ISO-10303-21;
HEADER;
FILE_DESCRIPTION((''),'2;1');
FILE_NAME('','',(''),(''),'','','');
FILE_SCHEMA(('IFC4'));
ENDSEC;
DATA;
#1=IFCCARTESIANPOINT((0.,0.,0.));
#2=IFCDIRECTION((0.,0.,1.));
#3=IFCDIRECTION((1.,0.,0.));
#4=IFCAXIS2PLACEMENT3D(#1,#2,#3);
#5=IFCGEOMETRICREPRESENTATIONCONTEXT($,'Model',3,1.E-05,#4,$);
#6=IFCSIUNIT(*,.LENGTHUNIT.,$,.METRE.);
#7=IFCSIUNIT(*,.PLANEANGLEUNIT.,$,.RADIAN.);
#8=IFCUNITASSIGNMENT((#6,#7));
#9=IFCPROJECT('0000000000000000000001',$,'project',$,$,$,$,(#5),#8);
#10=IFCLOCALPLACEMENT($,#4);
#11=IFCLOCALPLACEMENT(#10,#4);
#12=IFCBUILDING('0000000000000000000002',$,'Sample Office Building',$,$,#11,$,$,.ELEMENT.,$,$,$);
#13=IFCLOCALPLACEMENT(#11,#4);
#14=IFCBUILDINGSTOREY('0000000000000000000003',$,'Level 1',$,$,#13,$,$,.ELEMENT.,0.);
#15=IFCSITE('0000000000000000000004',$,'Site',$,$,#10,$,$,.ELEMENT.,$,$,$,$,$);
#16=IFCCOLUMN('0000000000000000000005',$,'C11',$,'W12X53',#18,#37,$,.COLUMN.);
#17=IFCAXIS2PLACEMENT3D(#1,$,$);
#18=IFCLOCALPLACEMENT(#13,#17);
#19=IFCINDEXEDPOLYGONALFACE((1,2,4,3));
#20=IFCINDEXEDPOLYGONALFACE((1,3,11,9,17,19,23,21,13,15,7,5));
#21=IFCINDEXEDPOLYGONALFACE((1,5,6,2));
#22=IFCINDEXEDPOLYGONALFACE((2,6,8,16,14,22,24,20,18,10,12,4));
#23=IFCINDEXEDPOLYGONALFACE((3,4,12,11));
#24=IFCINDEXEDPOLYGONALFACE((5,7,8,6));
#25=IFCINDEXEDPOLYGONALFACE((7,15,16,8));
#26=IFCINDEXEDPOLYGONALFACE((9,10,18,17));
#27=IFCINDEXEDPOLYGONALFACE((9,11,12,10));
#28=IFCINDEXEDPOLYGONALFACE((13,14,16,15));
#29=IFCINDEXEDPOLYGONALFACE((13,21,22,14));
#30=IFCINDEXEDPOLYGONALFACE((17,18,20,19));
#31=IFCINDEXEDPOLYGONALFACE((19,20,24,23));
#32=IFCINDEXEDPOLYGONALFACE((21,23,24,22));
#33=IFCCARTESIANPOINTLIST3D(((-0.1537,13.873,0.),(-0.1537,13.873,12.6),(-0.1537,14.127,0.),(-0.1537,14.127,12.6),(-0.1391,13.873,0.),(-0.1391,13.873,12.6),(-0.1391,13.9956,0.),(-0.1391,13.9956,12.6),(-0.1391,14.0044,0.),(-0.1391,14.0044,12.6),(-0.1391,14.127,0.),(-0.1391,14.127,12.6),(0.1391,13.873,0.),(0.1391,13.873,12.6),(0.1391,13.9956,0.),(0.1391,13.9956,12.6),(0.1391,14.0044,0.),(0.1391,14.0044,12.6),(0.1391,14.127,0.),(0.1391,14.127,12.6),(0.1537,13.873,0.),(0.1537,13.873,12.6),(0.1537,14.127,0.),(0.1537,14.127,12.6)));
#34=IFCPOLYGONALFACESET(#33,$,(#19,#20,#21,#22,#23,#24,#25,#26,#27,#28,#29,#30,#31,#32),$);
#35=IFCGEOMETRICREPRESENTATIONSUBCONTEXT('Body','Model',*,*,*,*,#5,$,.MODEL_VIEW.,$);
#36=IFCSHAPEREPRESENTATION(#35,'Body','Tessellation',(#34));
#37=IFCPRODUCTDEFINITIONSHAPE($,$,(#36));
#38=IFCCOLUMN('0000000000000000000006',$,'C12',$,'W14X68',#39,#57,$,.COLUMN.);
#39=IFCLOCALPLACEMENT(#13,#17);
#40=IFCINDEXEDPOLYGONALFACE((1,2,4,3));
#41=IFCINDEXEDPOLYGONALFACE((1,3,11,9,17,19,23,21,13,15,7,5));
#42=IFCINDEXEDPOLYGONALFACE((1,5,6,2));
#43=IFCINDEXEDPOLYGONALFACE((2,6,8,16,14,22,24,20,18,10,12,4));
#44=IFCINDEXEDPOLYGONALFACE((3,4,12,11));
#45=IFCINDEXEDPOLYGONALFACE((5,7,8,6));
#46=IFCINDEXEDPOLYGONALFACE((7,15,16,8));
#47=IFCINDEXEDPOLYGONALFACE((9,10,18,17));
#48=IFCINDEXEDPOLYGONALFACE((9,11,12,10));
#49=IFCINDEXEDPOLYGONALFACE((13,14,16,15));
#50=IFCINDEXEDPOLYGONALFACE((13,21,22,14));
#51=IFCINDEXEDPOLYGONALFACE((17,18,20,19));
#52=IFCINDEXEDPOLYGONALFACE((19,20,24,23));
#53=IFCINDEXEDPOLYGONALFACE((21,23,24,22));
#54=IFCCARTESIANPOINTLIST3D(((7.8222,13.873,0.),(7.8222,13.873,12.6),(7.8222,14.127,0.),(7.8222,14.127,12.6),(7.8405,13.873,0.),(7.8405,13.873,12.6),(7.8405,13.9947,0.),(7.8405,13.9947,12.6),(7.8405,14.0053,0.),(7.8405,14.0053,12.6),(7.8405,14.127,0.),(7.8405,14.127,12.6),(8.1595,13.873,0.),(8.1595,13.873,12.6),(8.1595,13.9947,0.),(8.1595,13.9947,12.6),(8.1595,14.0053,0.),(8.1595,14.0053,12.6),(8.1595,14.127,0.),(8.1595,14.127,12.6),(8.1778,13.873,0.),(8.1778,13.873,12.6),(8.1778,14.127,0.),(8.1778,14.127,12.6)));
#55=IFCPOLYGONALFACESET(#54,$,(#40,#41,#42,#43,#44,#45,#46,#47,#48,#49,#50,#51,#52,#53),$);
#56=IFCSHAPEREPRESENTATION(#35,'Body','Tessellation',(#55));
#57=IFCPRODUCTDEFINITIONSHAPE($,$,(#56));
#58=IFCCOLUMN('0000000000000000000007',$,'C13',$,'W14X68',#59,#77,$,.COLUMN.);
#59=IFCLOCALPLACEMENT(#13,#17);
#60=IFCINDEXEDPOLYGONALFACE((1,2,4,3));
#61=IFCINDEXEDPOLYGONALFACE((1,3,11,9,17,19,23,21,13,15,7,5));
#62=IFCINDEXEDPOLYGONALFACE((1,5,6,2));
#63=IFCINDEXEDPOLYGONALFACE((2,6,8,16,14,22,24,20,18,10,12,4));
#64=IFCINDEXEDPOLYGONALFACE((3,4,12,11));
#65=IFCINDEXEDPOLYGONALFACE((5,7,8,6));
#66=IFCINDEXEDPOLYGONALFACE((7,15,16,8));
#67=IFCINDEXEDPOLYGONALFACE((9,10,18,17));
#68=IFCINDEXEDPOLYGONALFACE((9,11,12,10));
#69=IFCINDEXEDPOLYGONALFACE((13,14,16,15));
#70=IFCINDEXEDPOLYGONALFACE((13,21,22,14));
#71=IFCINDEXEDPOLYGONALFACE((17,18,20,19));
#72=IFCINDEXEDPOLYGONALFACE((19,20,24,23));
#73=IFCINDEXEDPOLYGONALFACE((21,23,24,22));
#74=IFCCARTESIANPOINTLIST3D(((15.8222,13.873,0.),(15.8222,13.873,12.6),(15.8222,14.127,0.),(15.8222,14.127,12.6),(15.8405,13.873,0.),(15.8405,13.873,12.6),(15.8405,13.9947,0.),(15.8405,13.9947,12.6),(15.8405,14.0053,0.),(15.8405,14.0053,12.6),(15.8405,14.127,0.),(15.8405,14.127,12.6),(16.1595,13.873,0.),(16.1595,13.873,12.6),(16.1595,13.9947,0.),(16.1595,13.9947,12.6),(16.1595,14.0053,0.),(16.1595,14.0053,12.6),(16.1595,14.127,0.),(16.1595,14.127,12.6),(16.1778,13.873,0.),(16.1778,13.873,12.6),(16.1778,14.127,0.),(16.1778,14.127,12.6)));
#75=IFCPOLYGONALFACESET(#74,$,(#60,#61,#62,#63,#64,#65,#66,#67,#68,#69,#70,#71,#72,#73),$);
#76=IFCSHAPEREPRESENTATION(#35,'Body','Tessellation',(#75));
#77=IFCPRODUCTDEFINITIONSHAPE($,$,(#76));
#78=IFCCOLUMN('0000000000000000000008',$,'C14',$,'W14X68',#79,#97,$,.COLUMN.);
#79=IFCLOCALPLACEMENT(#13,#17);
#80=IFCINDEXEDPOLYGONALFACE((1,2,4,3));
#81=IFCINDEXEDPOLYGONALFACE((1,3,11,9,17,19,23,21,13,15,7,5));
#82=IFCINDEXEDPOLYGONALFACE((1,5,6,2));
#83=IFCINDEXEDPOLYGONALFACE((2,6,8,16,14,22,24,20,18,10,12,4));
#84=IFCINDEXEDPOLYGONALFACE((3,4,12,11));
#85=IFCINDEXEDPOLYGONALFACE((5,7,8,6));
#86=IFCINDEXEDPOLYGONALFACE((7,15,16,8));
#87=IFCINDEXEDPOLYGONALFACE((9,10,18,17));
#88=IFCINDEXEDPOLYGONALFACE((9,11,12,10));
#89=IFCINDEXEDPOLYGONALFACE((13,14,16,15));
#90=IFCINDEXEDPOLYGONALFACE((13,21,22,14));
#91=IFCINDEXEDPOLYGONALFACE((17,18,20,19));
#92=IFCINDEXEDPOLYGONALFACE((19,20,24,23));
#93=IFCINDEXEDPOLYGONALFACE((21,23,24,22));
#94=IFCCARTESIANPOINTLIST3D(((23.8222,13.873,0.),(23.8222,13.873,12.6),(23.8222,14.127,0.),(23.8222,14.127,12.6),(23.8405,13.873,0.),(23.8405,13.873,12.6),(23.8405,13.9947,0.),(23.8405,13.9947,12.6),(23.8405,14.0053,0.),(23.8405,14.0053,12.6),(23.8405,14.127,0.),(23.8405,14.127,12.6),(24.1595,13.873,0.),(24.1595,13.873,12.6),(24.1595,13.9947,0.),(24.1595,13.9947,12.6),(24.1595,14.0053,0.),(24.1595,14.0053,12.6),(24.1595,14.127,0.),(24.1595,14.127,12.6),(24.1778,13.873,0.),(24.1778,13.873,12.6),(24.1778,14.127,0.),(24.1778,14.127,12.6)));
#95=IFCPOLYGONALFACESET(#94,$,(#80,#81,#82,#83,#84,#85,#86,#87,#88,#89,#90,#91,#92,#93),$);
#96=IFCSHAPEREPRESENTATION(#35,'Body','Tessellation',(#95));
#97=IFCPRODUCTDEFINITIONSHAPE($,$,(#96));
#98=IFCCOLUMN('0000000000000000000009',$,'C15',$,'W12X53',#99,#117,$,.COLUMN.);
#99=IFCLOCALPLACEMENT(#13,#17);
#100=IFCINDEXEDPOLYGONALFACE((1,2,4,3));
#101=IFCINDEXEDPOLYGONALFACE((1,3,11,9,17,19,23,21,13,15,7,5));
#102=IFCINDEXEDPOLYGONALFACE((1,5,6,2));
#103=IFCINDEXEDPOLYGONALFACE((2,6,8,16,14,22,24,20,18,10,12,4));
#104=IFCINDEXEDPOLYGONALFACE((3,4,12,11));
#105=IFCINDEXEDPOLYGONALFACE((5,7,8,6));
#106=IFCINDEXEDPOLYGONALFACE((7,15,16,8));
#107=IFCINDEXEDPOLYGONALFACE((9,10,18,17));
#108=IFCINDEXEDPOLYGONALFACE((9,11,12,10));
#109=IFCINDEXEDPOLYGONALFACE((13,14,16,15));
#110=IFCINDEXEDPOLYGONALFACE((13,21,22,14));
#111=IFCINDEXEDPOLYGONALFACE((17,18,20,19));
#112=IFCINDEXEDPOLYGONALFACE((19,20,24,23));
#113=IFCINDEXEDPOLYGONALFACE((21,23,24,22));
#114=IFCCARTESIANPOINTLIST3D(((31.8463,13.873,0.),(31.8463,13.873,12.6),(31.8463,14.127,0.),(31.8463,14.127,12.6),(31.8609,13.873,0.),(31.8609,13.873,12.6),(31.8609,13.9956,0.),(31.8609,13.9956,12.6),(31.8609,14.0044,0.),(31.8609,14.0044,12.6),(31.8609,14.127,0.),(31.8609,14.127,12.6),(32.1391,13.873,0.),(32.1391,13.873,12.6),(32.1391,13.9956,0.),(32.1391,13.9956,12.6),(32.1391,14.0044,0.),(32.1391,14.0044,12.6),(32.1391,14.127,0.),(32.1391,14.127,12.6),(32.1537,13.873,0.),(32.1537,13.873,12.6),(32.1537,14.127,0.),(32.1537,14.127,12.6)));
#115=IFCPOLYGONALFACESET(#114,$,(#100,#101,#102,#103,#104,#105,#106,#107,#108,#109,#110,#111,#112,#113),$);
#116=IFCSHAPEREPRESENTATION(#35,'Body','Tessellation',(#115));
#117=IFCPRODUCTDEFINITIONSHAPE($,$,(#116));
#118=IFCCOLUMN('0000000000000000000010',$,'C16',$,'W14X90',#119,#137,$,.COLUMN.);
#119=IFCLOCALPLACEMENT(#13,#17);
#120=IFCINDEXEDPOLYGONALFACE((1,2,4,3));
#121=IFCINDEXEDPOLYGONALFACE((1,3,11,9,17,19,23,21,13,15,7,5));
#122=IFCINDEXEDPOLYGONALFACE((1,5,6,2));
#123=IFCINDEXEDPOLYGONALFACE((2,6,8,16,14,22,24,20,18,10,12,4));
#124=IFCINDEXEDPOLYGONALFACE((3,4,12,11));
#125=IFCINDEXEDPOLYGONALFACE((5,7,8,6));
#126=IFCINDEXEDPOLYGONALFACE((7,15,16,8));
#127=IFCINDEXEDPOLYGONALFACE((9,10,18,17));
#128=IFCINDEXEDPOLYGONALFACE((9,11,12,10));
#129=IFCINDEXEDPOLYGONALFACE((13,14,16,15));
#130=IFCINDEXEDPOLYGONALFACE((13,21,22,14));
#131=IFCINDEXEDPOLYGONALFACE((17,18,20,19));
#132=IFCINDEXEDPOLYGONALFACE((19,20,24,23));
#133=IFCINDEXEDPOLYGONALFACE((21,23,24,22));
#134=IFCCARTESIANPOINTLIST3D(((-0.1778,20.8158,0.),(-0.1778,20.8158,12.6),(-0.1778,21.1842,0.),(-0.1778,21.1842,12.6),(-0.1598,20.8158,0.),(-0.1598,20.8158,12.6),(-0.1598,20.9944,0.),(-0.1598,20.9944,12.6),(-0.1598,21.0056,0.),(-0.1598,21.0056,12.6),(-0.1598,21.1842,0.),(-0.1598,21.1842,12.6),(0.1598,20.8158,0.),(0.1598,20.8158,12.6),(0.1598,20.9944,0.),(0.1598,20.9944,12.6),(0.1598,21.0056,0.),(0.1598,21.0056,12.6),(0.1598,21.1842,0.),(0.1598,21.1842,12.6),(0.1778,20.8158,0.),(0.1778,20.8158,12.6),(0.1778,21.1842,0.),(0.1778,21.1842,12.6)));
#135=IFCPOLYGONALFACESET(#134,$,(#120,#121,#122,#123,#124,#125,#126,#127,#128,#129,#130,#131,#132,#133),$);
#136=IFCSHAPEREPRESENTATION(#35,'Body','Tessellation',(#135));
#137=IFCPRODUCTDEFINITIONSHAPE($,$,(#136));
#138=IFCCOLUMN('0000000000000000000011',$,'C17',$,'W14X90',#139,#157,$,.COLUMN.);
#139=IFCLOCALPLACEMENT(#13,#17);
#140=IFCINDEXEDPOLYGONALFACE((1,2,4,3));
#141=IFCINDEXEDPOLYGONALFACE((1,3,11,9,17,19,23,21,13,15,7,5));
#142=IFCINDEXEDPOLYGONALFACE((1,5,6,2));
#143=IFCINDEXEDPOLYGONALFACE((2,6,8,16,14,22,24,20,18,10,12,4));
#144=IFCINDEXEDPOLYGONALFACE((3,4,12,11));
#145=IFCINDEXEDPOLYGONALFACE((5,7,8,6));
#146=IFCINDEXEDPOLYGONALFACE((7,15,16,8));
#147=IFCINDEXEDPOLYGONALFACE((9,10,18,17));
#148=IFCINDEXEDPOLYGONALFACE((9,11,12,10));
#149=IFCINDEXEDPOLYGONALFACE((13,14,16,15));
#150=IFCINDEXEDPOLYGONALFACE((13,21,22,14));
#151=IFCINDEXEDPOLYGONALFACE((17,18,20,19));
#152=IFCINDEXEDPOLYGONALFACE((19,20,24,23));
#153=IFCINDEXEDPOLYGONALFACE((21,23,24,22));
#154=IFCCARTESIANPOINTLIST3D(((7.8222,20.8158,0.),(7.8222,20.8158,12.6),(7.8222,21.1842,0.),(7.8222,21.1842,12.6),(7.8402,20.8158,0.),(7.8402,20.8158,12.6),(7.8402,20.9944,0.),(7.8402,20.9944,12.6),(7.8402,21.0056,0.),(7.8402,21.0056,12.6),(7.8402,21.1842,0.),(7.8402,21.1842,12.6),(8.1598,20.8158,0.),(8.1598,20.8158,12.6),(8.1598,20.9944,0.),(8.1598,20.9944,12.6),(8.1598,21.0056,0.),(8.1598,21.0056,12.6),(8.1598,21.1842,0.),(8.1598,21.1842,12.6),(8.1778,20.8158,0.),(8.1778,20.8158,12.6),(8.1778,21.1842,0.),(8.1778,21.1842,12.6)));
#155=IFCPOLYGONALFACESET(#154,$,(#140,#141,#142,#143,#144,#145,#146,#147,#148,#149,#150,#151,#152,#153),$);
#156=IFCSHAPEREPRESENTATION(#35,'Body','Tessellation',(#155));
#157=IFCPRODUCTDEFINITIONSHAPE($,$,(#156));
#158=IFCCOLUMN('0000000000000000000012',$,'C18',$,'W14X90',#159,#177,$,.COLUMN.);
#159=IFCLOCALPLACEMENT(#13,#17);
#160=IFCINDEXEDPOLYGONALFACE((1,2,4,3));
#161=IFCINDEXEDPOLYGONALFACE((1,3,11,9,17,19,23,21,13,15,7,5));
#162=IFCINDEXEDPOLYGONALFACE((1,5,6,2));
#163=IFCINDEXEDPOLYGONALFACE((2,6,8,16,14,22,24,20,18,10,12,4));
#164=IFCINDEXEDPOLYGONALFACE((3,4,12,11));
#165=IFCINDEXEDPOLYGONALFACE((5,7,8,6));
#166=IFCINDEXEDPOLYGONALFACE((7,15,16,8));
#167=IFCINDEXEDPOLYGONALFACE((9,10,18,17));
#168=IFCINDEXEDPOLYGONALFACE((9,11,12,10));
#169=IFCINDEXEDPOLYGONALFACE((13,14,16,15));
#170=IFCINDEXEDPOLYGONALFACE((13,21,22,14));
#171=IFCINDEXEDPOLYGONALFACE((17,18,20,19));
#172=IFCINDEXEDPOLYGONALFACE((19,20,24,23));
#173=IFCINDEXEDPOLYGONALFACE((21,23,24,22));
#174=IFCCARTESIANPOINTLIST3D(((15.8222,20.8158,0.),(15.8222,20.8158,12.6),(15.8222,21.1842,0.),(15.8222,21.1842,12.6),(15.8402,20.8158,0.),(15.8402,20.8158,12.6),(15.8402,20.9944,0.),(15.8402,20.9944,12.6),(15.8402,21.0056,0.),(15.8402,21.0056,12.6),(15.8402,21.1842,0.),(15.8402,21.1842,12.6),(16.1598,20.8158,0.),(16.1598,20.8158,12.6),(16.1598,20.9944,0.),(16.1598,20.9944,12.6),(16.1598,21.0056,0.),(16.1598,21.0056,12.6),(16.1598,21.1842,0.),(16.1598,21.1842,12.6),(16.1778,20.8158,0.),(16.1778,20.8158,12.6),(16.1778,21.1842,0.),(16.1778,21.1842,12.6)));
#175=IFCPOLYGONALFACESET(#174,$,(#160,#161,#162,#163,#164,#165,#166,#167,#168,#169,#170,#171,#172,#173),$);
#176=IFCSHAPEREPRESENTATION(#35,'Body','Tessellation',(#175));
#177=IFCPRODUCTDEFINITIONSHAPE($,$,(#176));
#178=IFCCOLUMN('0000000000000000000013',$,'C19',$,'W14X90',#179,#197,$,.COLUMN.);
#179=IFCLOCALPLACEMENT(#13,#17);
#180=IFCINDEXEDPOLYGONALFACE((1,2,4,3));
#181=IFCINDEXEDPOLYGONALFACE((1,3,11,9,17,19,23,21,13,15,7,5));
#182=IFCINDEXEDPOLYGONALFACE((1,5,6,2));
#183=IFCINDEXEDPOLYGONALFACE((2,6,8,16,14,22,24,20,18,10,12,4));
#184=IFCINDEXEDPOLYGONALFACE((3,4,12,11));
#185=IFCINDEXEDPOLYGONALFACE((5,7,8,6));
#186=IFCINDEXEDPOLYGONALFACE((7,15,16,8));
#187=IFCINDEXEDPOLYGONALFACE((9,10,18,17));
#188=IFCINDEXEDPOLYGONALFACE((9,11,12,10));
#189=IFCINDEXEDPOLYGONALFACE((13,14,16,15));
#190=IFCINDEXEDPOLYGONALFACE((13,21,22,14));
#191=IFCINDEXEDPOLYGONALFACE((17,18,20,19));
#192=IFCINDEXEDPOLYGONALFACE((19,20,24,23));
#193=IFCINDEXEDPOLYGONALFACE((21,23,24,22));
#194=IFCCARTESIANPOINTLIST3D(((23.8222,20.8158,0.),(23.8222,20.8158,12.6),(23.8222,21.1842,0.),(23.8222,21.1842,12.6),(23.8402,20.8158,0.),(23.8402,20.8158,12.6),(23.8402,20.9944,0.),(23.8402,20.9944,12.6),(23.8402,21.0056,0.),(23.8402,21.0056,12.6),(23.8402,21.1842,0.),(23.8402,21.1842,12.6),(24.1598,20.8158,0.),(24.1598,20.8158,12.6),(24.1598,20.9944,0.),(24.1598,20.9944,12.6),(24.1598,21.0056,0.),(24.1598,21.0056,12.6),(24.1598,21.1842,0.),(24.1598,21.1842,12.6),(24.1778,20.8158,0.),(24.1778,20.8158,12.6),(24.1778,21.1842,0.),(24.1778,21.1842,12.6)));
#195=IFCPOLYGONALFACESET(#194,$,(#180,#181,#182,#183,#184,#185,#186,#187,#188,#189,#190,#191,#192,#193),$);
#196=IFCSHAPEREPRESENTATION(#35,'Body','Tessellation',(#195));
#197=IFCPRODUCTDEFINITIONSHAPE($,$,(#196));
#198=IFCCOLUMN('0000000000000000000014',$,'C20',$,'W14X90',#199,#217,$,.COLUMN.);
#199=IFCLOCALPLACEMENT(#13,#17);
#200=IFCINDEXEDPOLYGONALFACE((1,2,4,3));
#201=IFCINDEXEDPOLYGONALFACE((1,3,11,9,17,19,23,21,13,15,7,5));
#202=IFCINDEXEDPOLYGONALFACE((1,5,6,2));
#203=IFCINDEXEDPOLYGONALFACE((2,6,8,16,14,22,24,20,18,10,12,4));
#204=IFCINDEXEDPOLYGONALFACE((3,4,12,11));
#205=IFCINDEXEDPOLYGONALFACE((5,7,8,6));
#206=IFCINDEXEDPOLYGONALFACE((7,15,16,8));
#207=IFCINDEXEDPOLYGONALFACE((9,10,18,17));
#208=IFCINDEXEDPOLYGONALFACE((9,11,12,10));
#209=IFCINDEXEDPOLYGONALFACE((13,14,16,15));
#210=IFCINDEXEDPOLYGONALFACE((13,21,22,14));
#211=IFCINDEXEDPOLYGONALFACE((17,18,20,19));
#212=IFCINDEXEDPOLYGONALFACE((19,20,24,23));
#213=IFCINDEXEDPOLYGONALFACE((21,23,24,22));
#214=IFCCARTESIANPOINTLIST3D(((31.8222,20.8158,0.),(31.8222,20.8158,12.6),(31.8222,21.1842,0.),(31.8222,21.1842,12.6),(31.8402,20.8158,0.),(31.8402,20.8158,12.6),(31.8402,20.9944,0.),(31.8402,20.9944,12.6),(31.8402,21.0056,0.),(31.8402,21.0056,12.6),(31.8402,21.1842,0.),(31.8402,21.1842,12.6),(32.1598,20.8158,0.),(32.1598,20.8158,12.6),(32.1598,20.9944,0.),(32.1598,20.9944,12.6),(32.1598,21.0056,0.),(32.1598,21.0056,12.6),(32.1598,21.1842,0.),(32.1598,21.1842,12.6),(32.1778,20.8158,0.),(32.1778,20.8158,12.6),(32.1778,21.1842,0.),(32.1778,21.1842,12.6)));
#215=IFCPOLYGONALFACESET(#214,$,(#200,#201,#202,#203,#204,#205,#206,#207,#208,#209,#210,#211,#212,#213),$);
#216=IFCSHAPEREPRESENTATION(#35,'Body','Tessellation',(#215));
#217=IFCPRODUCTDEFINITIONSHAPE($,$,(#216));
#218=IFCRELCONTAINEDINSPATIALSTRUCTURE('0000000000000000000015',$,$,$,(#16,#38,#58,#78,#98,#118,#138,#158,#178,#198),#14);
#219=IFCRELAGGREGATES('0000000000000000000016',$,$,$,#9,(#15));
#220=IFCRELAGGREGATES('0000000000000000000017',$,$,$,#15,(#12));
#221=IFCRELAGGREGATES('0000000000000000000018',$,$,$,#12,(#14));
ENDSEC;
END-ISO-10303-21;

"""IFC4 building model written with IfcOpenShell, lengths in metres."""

from ifc_helpers import new_model, si_unit, frame, origin_with_axes, place, context, subcontext, project, spatial, i_section, extrude, element, save


model = new_model("IFC4")

# Units and contexts
model_context = context("Model", 3, precision=1e-05, world=origin_with_axes())
body_context = subcontext(model_context, "Body", "Model", "MODEL_VIEW")
ifc_project = project(units=[si_unit("LENGTHUNIT", "METRE"), si_unit("PLANEANGLEUNIT", "RADIAN")], contexts=[model_context])

# Site, building, storey
site_placement = place(None, origin_with_axes())
site = spatial("IfcSite", under=ifc_project, at=site_placement, Name="Site", CompositionType="ELEMENT")
building_placement = place(site_placement, origin_with_axes())
building = spatial("IfcBuilding", under=site, at=building_placement, Name="Sample Office Building", CompositionType="ELEMENT")
storey_placement = place(building_placement, origin_with_axes())
storey = spatial("IfcBuildingStorey", under=building, at=storey_placement, Name="Level 1", CompositionType="ELEMENT", Elevation=0.0)

# Columns
for number, where, z_axis, x_axis, name in (
    (1, (0.0, 14.0, 0.0), (0.0, 0.0, 1.0), (0.0, 1.0, 0.0), "C11"),
):
    element("IfcColumn", number, at=place(None, frame(where, z_axis=z_axis, x_axis=x_axis)), inside=storey, Name=name, ObjectType="W12X53", PredefinedType="COLUMN", context=body_context, shape_type="SweptSolid", body=[
        extrude(i_section(OverallWidth=0.254, OverallDepth=0.3073, WebThickness=0.0088, FlangeThickness=0.0146), None, (0.0, 0.0, 1.0), 12.6),
    ])
for number, where, z_axis, x_axis, name in (
    (2, (8.0, 14.0, 0.0), (0.0, 0.0, 1.0), (0.0, 1.0, 0.0), "C12"),
    (3, (16.0, 14.0, 0.0), (0.0, 0.0, 1.0), (0.0, 1.0, 0.0), "C13"),
    (4, (24.0, 14.0, 0.0), (0.0, 0.0, 1.0), (0.0, 1.0, 0.0), "C14"),
):
    element("IfcColumn", number, at=place(None, frame(where, z_axis=z_axis, x_axis=x_axis)), inside=storey, Name=name, ObjectType="W14X68", PredefinedType="COLUMN", context=body_context, shape_type="SweptSolid", body=[
        extrude(i_section(OverallWidth=0.254, OverallDepth=0.3556, WebThickness=0.0105, FlangeThickness=0.0183), None, (0.0, 0.0, 1.0), 12.6),
    ])
column_placement = place(None, frame((32.0, 14.0, 0.0), z_axis=(0.0, 0.0, 1.0), x_axis=(0.0, 1.0, 0.0)))
element("IfcColumn", 5, at=column_placement, inside=storey, Name="C15", ObjectType="W12X53", PredefinedType="COLUMN", context=body_context, shape_type="SweptSolid", body=[
    extrude(i_section(OverallWidth=0.254, OverallDepth=0.3073, WebThickness=0.0088, FlangeThickness=0.0146), None, (0.0, 0.0, 1.0), 12.6),
])
for number, where, z_axis, x_axis, name in (
    (6, (0.0, 21.0, 0.0), (0.0, 0.0, 1.0), (0.0, 1.0, 0.0), "C16"),
    (7, (8.0, 21.0, 0.0), (0.0, 0.0, 1.0), (0.0, 1.0, 0.0), "C17"),
    (8, (16.0, 21.0, 0.0), (0.0, 0.0, 1.0), (0.0, 1.0, 0.0), "C18"),
    (9, (24.0, 21.0, 0.0), (0.0, 0.0, 1.0), (0.0, 1.0, 0.0), "C19"),
    (10, (32.0, 21.0, 0.0), (0.0, 0.0, 1.0), (0.0, 1.0, 0.0), "C20"),
):
    element("IfcColumn", number, at=place(None, frame(where, z_axis=z_axis, x_axis=x_axis)), inside=storey, Name=name, ObjectType="W14X90", PredefinedType="COLUMN", context=body_context, shape_type="SweptSolid", body=[
        extrude(i_section(OverallWidth=0.3683, OverallDepth=0.3556, WebThickness=0.0112, FlangeThickness=0.018), None, (0.0, 0.0, 1.0), 12.6),
    ])

save(model, "model.ifc")
